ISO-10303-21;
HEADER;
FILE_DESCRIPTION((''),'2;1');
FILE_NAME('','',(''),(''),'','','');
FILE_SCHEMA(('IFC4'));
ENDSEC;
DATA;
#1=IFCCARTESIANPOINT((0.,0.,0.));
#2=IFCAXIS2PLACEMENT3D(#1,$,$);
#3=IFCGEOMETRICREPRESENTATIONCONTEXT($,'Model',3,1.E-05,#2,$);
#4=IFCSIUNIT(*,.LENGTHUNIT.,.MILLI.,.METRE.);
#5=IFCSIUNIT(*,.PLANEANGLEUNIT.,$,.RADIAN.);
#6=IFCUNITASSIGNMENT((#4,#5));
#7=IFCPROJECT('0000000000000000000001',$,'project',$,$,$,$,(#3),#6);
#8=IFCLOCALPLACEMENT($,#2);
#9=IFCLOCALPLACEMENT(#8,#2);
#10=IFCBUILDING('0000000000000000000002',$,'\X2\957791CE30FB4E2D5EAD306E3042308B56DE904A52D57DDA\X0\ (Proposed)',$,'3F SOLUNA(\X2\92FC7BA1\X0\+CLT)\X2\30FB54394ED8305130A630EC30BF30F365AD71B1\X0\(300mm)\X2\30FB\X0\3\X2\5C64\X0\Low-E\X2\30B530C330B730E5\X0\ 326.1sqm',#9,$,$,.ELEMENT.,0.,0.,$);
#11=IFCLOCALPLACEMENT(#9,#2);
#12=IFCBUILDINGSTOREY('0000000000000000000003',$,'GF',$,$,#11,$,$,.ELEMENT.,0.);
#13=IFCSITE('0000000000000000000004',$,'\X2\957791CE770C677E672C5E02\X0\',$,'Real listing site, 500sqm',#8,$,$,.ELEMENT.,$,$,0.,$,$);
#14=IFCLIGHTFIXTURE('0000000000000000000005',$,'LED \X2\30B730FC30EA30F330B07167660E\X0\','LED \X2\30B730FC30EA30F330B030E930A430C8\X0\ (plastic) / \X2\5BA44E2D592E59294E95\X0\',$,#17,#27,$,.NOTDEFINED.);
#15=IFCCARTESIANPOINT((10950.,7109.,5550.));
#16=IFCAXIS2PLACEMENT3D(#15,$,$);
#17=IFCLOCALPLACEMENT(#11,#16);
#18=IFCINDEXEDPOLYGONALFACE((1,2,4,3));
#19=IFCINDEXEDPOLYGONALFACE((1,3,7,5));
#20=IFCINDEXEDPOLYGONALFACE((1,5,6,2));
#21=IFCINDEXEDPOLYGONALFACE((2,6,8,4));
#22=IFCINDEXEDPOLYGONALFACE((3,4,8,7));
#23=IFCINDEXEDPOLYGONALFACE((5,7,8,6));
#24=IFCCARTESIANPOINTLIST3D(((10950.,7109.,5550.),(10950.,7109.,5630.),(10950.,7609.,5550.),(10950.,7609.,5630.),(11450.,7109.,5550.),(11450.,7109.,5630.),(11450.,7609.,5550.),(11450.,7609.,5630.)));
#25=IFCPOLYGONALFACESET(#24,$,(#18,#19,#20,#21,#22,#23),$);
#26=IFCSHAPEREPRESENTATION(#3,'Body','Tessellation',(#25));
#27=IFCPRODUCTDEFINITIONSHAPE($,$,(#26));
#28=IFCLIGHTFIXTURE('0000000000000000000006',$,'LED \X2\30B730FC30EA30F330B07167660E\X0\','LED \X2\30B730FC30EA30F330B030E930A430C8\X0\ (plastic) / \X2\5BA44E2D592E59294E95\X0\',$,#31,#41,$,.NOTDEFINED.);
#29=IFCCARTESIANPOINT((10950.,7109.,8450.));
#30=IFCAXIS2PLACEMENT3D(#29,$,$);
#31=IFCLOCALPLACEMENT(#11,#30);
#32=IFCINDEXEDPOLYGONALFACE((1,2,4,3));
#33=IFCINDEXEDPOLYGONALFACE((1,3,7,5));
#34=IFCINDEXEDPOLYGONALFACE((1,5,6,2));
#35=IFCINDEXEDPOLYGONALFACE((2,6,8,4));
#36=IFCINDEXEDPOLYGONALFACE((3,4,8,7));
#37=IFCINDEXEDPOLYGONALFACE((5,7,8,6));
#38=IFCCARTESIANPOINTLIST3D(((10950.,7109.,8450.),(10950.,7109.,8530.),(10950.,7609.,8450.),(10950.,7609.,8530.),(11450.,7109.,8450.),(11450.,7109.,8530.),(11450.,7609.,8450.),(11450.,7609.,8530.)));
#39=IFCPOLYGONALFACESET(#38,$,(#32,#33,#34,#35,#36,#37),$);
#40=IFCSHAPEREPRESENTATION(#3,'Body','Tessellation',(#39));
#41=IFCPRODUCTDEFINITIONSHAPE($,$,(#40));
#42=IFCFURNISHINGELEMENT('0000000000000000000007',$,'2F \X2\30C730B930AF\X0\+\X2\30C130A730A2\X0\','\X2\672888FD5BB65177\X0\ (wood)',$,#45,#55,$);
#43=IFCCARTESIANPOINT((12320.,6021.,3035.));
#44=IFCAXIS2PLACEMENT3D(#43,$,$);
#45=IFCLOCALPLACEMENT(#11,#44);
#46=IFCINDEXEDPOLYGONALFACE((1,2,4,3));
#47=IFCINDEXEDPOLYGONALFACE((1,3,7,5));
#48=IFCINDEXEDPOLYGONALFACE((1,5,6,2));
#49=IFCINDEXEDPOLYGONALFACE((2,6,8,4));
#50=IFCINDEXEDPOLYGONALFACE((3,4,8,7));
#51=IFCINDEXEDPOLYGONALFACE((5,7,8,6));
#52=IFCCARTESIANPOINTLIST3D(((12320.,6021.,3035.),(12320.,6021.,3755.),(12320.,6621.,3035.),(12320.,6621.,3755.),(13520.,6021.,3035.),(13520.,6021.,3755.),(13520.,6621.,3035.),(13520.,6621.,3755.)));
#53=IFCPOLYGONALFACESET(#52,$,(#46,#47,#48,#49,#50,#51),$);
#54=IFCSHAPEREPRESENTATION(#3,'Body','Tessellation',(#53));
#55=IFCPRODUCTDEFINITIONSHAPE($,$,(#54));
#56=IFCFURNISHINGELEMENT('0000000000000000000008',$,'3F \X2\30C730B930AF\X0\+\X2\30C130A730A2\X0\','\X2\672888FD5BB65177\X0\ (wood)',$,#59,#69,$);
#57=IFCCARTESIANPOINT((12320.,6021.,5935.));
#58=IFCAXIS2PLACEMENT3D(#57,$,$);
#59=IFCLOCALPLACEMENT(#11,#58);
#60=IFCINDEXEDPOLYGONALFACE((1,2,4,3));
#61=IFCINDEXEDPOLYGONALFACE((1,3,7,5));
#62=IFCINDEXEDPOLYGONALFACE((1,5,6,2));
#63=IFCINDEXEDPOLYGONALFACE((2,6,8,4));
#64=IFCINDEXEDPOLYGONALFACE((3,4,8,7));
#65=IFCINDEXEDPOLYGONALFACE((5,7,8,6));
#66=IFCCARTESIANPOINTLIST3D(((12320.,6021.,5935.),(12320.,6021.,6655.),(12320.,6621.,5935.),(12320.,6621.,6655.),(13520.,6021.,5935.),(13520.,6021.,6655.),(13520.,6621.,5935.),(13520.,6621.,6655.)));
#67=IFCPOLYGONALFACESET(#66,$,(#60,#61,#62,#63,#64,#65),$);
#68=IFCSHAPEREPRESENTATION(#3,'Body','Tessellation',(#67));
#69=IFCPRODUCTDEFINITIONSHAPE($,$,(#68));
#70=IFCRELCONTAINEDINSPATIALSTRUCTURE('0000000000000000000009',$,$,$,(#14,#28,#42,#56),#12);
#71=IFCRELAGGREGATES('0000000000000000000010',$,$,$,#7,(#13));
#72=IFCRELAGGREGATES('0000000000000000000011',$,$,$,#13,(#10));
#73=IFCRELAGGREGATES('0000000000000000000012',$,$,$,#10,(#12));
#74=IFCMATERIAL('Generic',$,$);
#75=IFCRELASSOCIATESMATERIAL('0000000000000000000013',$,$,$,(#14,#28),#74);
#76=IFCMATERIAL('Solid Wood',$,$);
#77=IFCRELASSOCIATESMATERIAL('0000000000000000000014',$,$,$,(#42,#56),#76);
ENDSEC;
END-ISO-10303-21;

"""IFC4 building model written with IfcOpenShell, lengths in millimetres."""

from ifc_helpers import new_model, si_unit, frame, frame_2d, origin, place, context, project, spatial, rectangle, extrude, material, element, save


model = new_model("IFC4")

# Units and contexts
model_context = context("Model", 3, precision=1e-05, world=origin())
ifc_project = project(units=[si_unit("LENGTHUNIT", "METRE", prefix="MILLI"), si_unit("PLANEANGLEUNIT", "RADIAN")], contexts=[model_context])

# Site, building, storey
site_placement = place(None, origin())
site = spatial("IfcSite", under=ifc_project, at=site_placement, Name="長野県松本市", ObjectType="Real listing site, 500sqm", CompositionType="ELEMENT", RefElevation=0.0)
building_placement = place(site_placement, origin())
building = spatial("IfcBuilding", under=site, at=building_placement, Name="長野・中庭のある回遊動線 (Proposed)", ObjectType="3F SOLUNA(鋼管+CLT)・吹付けウレタン断熱(300mm)・3層Low-Eサッシュ 326.1sqm", CompositionType="ELEMENT", ElevationOfRefHeight=0.0, ElevationOfTerrain=0.0)
storey_placement = place(building_placement, origin())
storey = spatial("IfcBuildingStorey", under=building, at=storey_placement, Name="GF", CompositionType="ELEMENT", Elevation=0.0)

# Shared definitions
ifc_material_1 = material(Name="Solid Wood")

# Light fixtures
ifc_material_2 = material(Name="Generic")
light_fixture_1_placement = place(storey_placement, frame((10950.0, 7109.0, 5550.0)))
element("IfcLightFixture", 1, at=light_fixture_1_placement, inside=storey, material=ifc_material_2, Name="LED シーリング照明", Description="LED シーリングライト (plastic) / 室中央天井", PredefinedType="NOTDEFINED", context=model_context, shape_type="SweptSolid", body=[
    extrude(rectangle(XDim=500.0, YDim=500.0, at=frame_2d((250.0, 250.0))), frame((10950.0, 7109.0, 5550.0)), (0.0, 0.0, 1.0), 80.0),
])
light_fixture_2_placement = place(storey_placement, frame((10950.0, 7109.0, 8450.0)))
element("IfcLightFixture", 2, at=light_fixture_2_placement, inside=storey, material=ifc_material_2, Name="LED シーリング照明", Description="LED シーリングライト (plastic) / 室中央天井", PredefinedType="NOTDEFINED", context=model_context, shape_type="SweptSolid", body=[
    extrude(rectangle(XDim=500.0, YDim=500.0, at=frame_2d((250.0, 250.0))), frame((10950.0, 7109.0, 8450.0)), (0.0, 0.0, 1.0), 80.0),
])

# Furnishing elements
furnishing_1_placement = place(storey_placement, frame((12320.0, 6021.0, 3035.0)))
element("IfcFurnishingElement", 3, at=furnishing_1_placement, inside=storey, material=ifc_material_1, Name="2F デスク+チェア", Description="木製家具 (wood)", context=model_context, shape_type="SweptSolid", body=[
    extrude(rectangle(XDim=1200.0, YDim=600.0, at=frame_2d((600.0, 300.0))), frame((12320.0, 6021.0, 3035.0)), (0.0, 0.0, 1.0), 720.0),
])
furnishing_2_placement = place(storey_placement, frame((12320.0, 6021.0, 5935.0)))
element("IfcFurnishingElement", 4, at=furnishing_2_placement, inside=storey, material=ifc_material_1, Name="3F デスク+チェア", Description="木製家具 (wood)", context=model_context, shape_type="SweptSolid", body=[
    extrude(rectangle(XDim=1200.0, YDim=600.0, at=frame_2d((600.0, 300.0))), frame((12320.0, 6021.0, 5935.0)), (0.0, 0.0, 1.0), 720.0),
])

save(model, "model.ifc")
